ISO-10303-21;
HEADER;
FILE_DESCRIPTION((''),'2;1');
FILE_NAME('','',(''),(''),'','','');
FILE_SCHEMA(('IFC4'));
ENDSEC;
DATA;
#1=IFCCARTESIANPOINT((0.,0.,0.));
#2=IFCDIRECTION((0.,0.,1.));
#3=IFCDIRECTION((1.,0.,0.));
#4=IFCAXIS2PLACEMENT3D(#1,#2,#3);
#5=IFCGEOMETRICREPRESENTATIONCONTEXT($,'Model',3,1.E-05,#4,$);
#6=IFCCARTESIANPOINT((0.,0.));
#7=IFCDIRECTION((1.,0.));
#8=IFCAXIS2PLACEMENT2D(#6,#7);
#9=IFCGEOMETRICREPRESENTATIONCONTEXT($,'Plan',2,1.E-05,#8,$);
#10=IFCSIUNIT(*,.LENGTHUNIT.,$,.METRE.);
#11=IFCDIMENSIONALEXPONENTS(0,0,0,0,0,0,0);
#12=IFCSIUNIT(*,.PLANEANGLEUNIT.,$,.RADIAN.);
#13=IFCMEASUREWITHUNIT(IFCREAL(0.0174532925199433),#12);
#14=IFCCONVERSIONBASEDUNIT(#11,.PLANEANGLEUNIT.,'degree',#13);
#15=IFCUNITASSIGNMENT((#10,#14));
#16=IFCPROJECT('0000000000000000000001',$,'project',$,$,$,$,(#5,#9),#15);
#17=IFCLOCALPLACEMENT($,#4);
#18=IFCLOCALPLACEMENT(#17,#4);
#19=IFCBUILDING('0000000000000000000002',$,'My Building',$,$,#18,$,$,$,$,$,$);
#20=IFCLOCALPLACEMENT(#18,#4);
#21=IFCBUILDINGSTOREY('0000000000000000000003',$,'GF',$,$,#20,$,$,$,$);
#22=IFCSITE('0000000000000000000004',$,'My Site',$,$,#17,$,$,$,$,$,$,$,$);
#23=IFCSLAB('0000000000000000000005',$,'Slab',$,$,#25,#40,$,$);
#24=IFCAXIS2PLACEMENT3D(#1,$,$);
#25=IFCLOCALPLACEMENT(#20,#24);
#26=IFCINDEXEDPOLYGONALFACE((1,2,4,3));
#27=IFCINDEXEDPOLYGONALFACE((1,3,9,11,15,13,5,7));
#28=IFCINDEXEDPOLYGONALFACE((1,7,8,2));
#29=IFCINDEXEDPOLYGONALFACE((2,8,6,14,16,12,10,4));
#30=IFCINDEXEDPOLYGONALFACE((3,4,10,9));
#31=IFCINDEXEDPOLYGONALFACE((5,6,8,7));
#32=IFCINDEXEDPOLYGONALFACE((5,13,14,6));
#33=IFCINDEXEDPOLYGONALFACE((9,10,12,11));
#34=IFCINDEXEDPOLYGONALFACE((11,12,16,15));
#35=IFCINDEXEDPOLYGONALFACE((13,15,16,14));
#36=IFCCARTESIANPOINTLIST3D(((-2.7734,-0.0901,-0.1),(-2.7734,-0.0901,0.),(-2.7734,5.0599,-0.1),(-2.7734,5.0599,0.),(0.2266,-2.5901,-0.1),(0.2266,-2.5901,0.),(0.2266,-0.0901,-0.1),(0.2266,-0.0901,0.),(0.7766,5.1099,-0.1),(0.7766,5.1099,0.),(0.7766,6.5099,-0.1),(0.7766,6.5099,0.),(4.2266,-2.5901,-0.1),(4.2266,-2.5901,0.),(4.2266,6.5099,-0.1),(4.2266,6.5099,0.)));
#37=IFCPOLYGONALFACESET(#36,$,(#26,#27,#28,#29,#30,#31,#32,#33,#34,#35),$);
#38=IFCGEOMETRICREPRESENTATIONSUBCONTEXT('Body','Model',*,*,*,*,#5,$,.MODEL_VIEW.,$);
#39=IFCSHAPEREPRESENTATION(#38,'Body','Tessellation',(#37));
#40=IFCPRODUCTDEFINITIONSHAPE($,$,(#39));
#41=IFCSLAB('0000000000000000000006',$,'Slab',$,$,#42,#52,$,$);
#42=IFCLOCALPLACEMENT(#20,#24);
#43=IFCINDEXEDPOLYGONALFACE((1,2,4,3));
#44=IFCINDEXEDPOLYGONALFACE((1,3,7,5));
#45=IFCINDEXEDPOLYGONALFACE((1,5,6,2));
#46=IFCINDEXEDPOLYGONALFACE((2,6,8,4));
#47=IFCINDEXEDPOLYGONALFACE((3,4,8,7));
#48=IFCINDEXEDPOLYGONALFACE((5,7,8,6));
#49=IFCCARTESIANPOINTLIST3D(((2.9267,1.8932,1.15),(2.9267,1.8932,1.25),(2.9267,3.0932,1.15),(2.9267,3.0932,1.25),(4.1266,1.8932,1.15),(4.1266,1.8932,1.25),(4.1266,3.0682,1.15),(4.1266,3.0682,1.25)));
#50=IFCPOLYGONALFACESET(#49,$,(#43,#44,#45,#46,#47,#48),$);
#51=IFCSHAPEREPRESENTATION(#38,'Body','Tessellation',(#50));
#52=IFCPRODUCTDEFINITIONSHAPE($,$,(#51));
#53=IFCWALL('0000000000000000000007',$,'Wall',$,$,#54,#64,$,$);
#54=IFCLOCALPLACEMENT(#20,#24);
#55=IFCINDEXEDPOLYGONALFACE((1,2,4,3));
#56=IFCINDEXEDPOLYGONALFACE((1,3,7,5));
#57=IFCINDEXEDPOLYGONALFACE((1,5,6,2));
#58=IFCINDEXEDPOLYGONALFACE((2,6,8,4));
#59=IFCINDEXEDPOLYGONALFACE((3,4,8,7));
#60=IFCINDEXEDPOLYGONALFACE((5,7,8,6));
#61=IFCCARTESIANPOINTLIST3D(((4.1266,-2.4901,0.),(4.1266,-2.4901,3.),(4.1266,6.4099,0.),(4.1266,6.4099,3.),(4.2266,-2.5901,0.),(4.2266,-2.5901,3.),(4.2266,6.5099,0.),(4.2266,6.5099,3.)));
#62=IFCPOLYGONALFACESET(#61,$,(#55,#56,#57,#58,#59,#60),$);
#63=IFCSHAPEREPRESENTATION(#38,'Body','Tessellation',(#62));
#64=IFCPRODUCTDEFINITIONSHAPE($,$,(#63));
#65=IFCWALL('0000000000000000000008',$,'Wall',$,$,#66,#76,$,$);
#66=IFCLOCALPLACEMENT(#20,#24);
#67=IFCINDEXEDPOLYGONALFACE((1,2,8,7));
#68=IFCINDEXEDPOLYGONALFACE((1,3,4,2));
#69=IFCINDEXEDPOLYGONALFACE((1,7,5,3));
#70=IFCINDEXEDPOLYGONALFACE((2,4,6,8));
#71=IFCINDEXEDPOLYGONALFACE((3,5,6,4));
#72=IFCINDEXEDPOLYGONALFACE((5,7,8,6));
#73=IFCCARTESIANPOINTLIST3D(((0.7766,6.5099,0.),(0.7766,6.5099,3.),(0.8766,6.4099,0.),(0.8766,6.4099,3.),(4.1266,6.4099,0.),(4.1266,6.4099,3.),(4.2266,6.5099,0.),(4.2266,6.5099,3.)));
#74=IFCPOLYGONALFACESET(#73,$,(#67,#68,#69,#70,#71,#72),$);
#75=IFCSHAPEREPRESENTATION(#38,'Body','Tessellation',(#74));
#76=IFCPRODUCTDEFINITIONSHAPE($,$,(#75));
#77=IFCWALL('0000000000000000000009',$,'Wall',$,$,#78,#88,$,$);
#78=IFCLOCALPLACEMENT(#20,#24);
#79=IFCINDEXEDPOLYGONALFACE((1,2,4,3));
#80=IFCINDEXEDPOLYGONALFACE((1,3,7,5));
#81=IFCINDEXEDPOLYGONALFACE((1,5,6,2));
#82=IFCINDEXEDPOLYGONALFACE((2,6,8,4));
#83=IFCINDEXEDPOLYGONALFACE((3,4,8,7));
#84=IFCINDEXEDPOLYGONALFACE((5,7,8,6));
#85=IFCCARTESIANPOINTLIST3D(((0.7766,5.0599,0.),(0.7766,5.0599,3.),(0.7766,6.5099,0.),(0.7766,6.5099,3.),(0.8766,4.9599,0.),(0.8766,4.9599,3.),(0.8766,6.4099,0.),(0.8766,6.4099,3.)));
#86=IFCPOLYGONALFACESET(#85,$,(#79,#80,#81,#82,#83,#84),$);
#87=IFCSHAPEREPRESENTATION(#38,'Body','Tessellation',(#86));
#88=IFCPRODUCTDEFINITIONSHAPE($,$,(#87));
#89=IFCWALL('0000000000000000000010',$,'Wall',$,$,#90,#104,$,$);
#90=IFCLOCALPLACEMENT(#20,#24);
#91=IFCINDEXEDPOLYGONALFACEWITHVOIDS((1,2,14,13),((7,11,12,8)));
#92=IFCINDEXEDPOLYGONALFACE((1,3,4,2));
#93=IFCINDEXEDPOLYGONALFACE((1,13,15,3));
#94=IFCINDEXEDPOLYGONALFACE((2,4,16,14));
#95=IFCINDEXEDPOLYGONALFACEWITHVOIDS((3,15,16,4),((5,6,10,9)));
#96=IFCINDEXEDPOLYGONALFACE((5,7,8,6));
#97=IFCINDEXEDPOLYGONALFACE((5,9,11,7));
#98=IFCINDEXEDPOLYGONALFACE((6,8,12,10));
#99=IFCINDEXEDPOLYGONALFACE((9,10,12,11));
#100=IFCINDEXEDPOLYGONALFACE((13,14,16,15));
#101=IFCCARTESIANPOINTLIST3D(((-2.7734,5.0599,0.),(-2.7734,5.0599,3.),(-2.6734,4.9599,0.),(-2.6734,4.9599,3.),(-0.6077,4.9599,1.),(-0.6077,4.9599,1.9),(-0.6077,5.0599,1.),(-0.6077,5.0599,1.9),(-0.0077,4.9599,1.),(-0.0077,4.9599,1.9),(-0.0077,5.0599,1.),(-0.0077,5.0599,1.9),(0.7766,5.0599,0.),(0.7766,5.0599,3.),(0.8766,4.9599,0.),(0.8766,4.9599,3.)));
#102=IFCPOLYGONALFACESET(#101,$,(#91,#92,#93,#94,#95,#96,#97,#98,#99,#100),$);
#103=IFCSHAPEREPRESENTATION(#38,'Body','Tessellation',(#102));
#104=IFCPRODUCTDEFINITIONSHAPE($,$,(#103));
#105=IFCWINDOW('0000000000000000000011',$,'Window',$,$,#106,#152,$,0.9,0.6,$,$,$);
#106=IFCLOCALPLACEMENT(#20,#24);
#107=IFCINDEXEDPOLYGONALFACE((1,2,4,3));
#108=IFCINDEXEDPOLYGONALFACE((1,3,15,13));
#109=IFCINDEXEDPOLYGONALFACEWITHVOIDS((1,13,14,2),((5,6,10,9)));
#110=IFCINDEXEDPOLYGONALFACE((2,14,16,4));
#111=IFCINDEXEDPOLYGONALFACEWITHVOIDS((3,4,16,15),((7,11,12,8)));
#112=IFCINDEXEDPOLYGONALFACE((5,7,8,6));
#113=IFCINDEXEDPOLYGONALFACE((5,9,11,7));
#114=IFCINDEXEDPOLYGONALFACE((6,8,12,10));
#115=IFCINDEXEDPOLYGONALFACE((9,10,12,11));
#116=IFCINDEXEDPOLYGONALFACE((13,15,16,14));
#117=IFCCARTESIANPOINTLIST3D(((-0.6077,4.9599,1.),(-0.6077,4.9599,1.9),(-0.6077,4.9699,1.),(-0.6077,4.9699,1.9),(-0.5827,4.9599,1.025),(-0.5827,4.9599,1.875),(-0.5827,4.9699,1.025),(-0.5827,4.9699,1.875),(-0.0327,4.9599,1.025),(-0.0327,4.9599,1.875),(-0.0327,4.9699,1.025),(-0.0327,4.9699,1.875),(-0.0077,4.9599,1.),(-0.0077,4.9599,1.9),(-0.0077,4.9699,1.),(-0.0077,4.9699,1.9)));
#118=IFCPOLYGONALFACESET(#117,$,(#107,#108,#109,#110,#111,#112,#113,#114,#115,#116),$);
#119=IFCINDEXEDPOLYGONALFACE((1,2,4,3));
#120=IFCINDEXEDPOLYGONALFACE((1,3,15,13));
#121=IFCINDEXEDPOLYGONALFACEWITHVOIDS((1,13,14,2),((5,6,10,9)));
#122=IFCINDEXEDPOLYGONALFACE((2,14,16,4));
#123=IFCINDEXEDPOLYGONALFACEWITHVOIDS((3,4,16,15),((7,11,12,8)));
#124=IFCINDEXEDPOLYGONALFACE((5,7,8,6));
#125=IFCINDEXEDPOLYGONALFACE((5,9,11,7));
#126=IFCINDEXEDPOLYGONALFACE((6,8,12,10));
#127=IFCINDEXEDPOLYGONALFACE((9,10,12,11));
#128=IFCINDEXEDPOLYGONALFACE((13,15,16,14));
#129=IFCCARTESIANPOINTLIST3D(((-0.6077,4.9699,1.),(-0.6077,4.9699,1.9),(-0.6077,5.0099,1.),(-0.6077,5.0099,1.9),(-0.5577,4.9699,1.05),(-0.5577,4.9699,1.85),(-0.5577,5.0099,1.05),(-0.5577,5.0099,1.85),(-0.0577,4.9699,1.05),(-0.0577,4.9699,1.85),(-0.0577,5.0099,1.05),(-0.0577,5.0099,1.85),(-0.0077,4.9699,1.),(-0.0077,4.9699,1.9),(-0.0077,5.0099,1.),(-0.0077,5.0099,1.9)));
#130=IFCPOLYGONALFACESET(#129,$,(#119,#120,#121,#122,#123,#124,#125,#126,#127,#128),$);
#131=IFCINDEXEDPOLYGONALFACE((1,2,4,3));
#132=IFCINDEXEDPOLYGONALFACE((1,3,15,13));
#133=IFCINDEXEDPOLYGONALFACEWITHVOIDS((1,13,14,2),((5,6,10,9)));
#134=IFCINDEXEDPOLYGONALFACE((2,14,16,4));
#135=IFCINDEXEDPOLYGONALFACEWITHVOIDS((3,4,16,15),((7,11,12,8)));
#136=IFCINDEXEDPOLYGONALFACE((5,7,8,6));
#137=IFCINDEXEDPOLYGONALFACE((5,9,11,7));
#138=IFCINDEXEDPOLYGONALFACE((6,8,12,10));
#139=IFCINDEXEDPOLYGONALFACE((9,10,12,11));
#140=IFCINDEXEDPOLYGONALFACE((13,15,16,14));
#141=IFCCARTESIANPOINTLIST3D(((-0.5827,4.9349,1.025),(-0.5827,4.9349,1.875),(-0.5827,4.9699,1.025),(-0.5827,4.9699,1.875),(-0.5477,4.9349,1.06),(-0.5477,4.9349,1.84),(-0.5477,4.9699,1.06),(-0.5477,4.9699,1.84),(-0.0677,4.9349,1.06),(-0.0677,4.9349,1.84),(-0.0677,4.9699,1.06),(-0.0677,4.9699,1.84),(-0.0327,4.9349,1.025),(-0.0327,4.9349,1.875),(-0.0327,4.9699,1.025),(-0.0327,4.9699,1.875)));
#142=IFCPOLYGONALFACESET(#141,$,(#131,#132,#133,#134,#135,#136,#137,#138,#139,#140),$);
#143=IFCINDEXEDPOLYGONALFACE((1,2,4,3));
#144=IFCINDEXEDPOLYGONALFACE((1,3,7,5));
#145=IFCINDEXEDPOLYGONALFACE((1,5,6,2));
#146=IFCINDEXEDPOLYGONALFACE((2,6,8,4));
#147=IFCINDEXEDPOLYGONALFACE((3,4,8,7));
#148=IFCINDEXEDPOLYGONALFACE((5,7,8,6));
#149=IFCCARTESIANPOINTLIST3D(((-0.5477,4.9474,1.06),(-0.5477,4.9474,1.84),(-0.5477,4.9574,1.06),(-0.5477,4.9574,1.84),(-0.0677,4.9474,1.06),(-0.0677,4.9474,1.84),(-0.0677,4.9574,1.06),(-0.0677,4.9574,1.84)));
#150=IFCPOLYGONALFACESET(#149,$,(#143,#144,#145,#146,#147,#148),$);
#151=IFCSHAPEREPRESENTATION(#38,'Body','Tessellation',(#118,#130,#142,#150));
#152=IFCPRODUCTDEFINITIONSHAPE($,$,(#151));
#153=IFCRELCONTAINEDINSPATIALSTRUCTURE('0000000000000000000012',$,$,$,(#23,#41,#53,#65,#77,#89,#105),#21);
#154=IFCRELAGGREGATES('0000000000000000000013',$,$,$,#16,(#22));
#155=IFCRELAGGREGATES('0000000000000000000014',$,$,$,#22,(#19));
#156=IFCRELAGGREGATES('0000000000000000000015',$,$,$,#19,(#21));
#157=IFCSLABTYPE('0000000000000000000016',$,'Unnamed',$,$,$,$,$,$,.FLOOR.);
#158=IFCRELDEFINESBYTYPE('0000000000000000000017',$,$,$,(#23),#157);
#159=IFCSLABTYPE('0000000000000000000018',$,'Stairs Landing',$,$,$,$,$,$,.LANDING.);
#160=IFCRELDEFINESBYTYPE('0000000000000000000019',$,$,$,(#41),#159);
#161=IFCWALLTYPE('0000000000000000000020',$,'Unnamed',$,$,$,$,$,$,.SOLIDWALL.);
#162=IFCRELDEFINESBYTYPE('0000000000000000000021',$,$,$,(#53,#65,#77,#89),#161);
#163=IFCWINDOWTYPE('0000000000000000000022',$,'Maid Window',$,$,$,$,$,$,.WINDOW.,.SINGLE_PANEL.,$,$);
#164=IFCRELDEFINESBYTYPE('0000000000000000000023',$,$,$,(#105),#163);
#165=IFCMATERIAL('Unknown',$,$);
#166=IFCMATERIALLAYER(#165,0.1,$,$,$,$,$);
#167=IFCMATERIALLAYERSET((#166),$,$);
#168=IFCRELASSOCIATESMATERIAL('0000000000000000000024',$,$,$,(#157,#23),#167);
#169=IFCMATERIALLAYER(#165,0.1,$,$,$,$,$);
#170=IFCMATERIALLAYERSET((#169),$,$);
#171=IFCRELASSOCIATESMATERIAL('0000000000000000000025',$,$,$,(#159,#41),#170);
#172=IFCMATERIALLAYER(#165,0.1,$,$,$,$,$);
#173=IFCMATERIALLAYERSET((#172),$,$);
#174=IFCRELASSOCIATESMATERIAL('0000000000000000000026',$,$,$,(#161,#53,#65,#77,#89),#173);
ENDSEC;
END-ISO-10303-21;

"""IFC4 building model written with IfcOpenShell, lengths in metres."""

from ifc_helpers import new_model, entity, si_unit, converted_unit, frame, origin_with_axes, origin_2d_with_axis, place, context, subcontext, project, spatial, line, indexed_curve, outline, extrude, shape, source, transform, mapped, material, layer, layer_set, layer_usage, type_object, type_shapes, element, fill, save


model = new_model("IFC4")

# Units and contexts
model_context = context("Model", 3, precision=1e-05, world=origin_with_axes())
plan_context = context("Plan", 2, precision=1e-05, world=origin_2d_with_axis())
body_context_1 = subcontext(model_context, "Body", "Model", "MODEL_VIEW")
body_context_2 = subcontext(plan_context, "Body", "Plan", "PLAN_VIEW")
ifc_project = project(units=[si_unit("LENGTHUNIT", "METRE"), converted_unit("PLANEANGLEUNIT", "degree", entity("IfcReal", 0.0174532925199433), si_unit("PLANEANGLEUNIT", "RADIAN"), dimensions=[0, 0, 0, 0, 0, 0, 0])], contexts=[model_context, plan_context])

# Site, building, storey
site_placement = place(None, origin_with_axes())
site = spatial("IfcSite", under=ifc_project, at=site_placement, Name="My Site")
building_placement = place(site_placement, origin_with_axes())
building = spatial("IfcBuilding", under=site, at=building_placement, Name="My Building")
storey_placement = place(building_placement, origin_with_axes())
storey = spatial("IfcBuildingStorey", under=building, at=storey_placement, Name="GF")

# Slabs
ifc_material_1 = material(Name="Unknown")
ifc_layer_1 = layer(ifc_material_1, 0.1)
ifc_layer_set_1 = layer_set([ifc_layer_1])
ifc_layer_usage_1 = layer_usage(ifc_layer_set_1, "AXIS3", "POSITIVE", -0.1)
slab_type_1 = type_object("IfcSlabType", Name="Unnamed", PredefinedType="FLOOR", material=ifc_layer_set_1)
slab_1_placement = place(storey_placement, frame((4.2266, 6.5099, 0.0), z_axis=(0.0, 0.0, 1.0), x_axis=(1.0, 0.0, 0.0)))
element("IfcSlab", 1, at=slab_1_placement, inside=storey, type_object=slab_type_1, material=ifc_layer_usage_1, Name="Slab", context=body_context_1, shape_type="SweptSolid", body=[
    extrude(outline(indexed_curve([(0.0, 0.0), (-3.45, 0.0), (-3.45, -1.4), (-7.0, -1.45), (-7.0, -6.6), (-4.0, -6.6), (-4.0, -9.1), (0.0, -9.1), (0.0, 0.0)])), frame((0.0, 0.0, -0.1), z_axis=(0.0, 0.0, 1.0), x_axis=(1.0, 0.0, 0.0)), (0.0, 0.0, 1.0), 0.1),
])
ifc_layer_2 = layer(ifc_material_1, 0.1)
ifc_layer_set_2 = layer_set([ifc_layer_2])
ifc_layer_usage_2 = layer_usage(ifc_layer_set_2, "AXIS3", "POSITIVE", -0.1)
slab_type_2 = type_object("IfcSlabType", Name="Stairs Landing", PredefinedType="LANDING", material=ifc_layer_set_2)
slab_2_placement = place(storey_placement, frame((4.1267, 1.8932, 1.25), z_axis=(0.0, 0.0, 1.0), x_axis=(1.0, 0.0, 0.0)))
element("IfcSlab", 2, at=slab_2_placement, inside=storey, type_object=slab_type_2, material=ifc_layer_usage_2, Name="Slab", context=body_context_1, shape_type="SweptSolid", body=[
    extrude(outline(indexed_curve([(-0.0001, -0.0001), (-0.0001, 1.175), (-1.2, 1.2), (-1.2, 0.0), (-0.0001, -0.0001)])), frame((0.0, 0.0, -0.1), z_axis=(0.0, 0.0, 1.0), x_axis=(1.0, 0.0, 0.0)), (0.0, 0.0, 1.0), 0.1),
])

# Shared definitions
ifc_layer_3 = layer(ifc_material_1, 0.1)
ifc_layer_set_3 = layer_set([ifc_layer_3])
wall_type = type_object("IfcWallType", Name="Unnamed", PredefinedType="SOLIDWALL", material=ifc_layer_set_3)

# Walls
ifc_layer_usage_3 = layer_usage(ifc_layer_set_3, "AXIS2", "POSITIVE", 0.0)
wall_1_placement = place(storey_placement, frame((4.2266, -2.5901, 0.0), z_axis=(0.0, 0.0, 1.0), x_axis=(0.0, 1.0, 0.0)))
element("IfcWall", 3, at=wall_1_placement, inside=storey, type_object=wall_type, material=ifc_layer_usage_3, Name="Wall", context=body_context_1, shape_type="SweptSolid", body=[
    extrude(outline(indexed_curve([(0.0, 0.0), (0.1, 0.1), (9.0, 0.1), (9.1, 0.0)], segments=[line(1, 2, 3, 4, 1)])), origin_with_axes(), (0.0, 0.0, 1.0), 3.0),
])
ifc_layer_usage_4 = layer_usage(ifc_layer_set_3, "AXIS2", "POSITIVE", 0.0)
wall_2_placement = place(storey_placement, frame((4.2266, 6.5099, 0.0), z_axis=(0.0, 0.0, 1.0), x_axis=(-1.0, 0.0, 0.0)))
element("IfcWall", 4, at=wall_2_placement, inside=storey, type_object=wall_type, material=ifc_layer_usage_4, Name="Wall", context=body_context_1, shape_type="SweptSolid", body=[
    extrude(outline(indexed_curve([(0.0, 0.0), (0.1, 0.1), (3.35, 0.1), (3.45, 0.0)], segments=[line(1, 2, 3, 4, 1)])), origin_with_axes(), (0.0, 0.0, 1.0), 3.0),
])
ifc_layer_usage_5 = layer_usage(ifc_layer_set_3, "AXIS2", "POSITIVE", 0.0)
wall_3_placement = place(storey_placement, frame((0.7766, 6.5099, 0.0), z_axis=(0.0, 0.0, 1.0), x_axis=(0.0, -1.0, 0.0)))
element("IfcWall", 5, at=wall_3_placement, inside=storey, type_object=wall_type, material=ifc_layer_usage_5, Name="Wall", context=body_context_1, shape_type="SweptSolid", body=[
    extrude(outline(indexed_curve([(0.0, 0.0), (0.1, 0.1), (1.55, 0.1), (1.45, 0.0)], segments=[line(1, 2, 3, 4, 1)])), origin_with_axes(), (0.0, 0.0, 1.0), 3.0),
])

# Wall, opening, window
ifc_layer_usage_6 = layer_usage(ifc_layer_set_3, "AXIS2", "POSITIVE", 0.0)
wall_4_placement = place(storey_placement, frame((0.7766, 5.0599, 0.0), z_axis=(0.0, 0.0, 1.0), x_axis=(-1.0, 0.0, 0.0)))
wall_4 = element("IfcWall", 6, at=wall_4_placement, inside=storey, type_object=wall_type, material=ifc_layer_usage_6, Name="Wall", context=body_context_1, shape_type="SweptSolid", body=[
    extrude(outline(indexed_curve([(0.0, 0.0), (-0.1, 0.1), (3.45, 0.1), (3.55, 0.0)], segments=[line(1, 2, 3, 4, 1)])), origin_with_axes(), (0.0, 0.0, 1.0), 3.0),
])
shared_shape_1 = source(origin_with_axes(), body_context_1, "Body", "SweptSolid", [
    extrude(outline(indexed_curve([(0.0, 0.0), (0.6, 0.0), (0.6, 0.9), (0.0, 0.9)], segments=[line(1, 2, 3, 4, 1)])), frame((0.0, -0.6, 0.0), z_axis=(0.0, -1.0, 0.0), x_axis=(1.0, 0.0, 0.0)), (0.0, 0.0, -1.0), 1.2),
])
opening_1_placement = place(wall_4_placement, frame((0.7843, 0.0, 1.0), z_axis=(0.0, 0.0, 1.0), x_axis=(1.0, 0.0, 0.0)))
opening_1 = element("IfcOpeningElement", 7, at=opening_1_placement, cuts=wall_4, PredefinedType="OPENING", context=body_context_1, shape_type="MappedRepresentation", body=[
    mapped(shared_shape_1, transform((0.0, 0.0, 0.0), x_axis=(1.0, 0.0, 0.0), y_axis=(0.0, 1.0, 0.0), z_axis=(0.0, 0.0, 1.0), scale=1.0)),
])
window_type_1 = type_object("IfcWindowType", Name="Maid Window", PartitioningType="SINGLE_PANEL", PredefinedType="WINDOW")
shared_shape_2 = source(origin_with_axes(), body_context_1, "Body", "SweptSolid", [
    extrude(outline(indexed_curve([(0.0, 0.0), (0.6, 0.0), (0.6, 0.9), (0.0, 0.9)], segments=[line(1, 2, 3, 4, 1)]), holes=[indexed_curve([(0.025, 0.025), (0.575, 0.025), (0.575, 0.875), (0.025, 0.875)], segments=[line(1, 2, 3, 4, 1)])]), frame((0.0, 0.09, 0.0), z_axis=(0.0, -1.0, 0.0), x_axis=(1.0, 0.0, 0.0)), (0.0, 0.0, -1.0), 0.01),
    extrude(outline(indexed_curve([(0.0, 0.0), (0.6, 0.0), (0.6, 0.9), (0.0, 0.9)], segments=[line(1, 2, 3, 4, 1)]), holes=[indexed_curve([(0.05, 0.05), (0.55, 0.05), (0.55, 0.85), (0.05, 0.85)], segments=[line(1, 2, 3, 4, 1)])]), frame((0.0, 0.05, 0.0), z_axis=(0.0, -1.0, 0.0), x_axis=(1.0, 0.0, 0.0)), (0.0, 0.0, -1.0), 0.04),
    extrude(outline(indexed_curve([(0.0, 0.0), (0.55, 0.0), (0.55, 0.85), (0.0, 0.85)], segments=[line(1, 2, 3, 4, 1)]), holes=[indexed_curve([(0.035, 0.035), (0.515, 0.035), (0.515, 0.815), (0.035, 0.815)], segments=[line(1, 2, 3, 4, 1)])]), frame((0.025, 0.09, 0.025), z_axis=(0.0, -1.0, 0.0), x_axis=(1.0, 0.0, 0.0)), (0.0, 0.0, -1.0), 0.035),
    extrude(outline(indexed_curve([(0.035, 0.035), (0.515, 0.035), (0.515, 0.815), (0.035, 0.815)], segments=[line(1, 2, 3, 4, 1)])), frame((0.025, 0.1025, 0.025), z_axis=(0.0, -1.0, 0.0), x_axis=(1.0, 0.0, 0.0)), (0.0, 0.0, -1.0), 0.01),
])
shared_shape_3 = source(origin_with_axes(), body_context_2, "Body", "Curve2D", [
    entity("IfcIndexedPolyCurve", entity("IfcCartesianPointList2D", [[0.05, 0.05], [0.55, 0.05]])),
    entity("IfcIndexedPolyCurve", entity("IfcCartesianPointList2D", [[0.0, 0.1], [0.025, 0.1], [0.025, 0.09], [0.05, 0.09], [0.05, 0.05], [0.0, 0.05]]), [entity("IfcLineIndex", [1, 2, 3, 4, 5, 6, 1])]),
    entity("IfcIndexedPolyCurve", entity("IfcCartesianPointList2D", [[0.6, 0.1], [0.575, 0.1], [0.575, 0.09], [0.55, 0.09], [0.55, 0.05], [0.6, 0.05]]), [entity("IfcLineIndex", [1, 2, 3, 4, 5, 6, 1])]),
    entity("IfcIndexedPolyCurve", entity("IfcCartesianPointList2D", [[0.025, 0.09], [0.06, 0.09], [0.06, 0.125], [0.025, 0.125]]), [entity("IfcLineIndex", [1, 2, 3, 4, 1])]),
    entity("IfcIndexedPolyCurve", entity("IfcCartesianPointList2D", [[0.575, 0.09], [0.54, 0.09], [0.54, 0.125], [0.575, 0.125]]), [entity("IfcLineIndex", [1, 2, 3, 4, 1])]),
    entity("IfcIndexedPolyCurve", entity("IfcCartesianPointList2D", [[0.06, 0.09], [0.54, 0.09]])),
    entity("IfcIndexedPolyCurve", entity("IfcCartesianPointList2D", [[0.06, 0.125], [0.54, 0.125]])),
    entity("IfcIndexedPolyCurve", entity("IfcCartesianPointList2D", [[0.06, 0.1075], [0.54, 0.1075]])),
])
type_shapes(window_type_1, [shared_shape_2, shared_shape_3])
window_1_placement = place(opening_1_placement, frame((0.0, 0.0, 0.0), z_axis=(0.0, 0.0, 1.0), x_axis=(1.0, 0.0, 0.0)))
window_1 = element("IfcWindow", 8, at=window_1_placement, inside=storey, type_object=window_type_1, Name="Window", OverallHeight=0.9, OverallWidth=0.6, shapes=[
    shape(body_context_1, "Body", "MappedRepresentation", [mapped(shared_shape_2, transform((0.0, 0.0, 0.0), x_axis=(1.0, 0.0, 0.0), y_axis=(0.0, 1.0, 0.0), z_axis=(0.0, 0.0, 1.0), scale=1.0))]),
    shape(body_context_2, "Body", "MappedRepresentation", [mapped(shared_shape_3, transform((0.0, 0.0, 0.0), x_axis=(1.0, 0.0, 0.0), y_axis=(0.0, 1.0, 0.0), z_axis=(0.0, 0.0, 1.0), scale=1.0))]),
])
fill(opening_1, window_1)

save(model, "model.ifc")
